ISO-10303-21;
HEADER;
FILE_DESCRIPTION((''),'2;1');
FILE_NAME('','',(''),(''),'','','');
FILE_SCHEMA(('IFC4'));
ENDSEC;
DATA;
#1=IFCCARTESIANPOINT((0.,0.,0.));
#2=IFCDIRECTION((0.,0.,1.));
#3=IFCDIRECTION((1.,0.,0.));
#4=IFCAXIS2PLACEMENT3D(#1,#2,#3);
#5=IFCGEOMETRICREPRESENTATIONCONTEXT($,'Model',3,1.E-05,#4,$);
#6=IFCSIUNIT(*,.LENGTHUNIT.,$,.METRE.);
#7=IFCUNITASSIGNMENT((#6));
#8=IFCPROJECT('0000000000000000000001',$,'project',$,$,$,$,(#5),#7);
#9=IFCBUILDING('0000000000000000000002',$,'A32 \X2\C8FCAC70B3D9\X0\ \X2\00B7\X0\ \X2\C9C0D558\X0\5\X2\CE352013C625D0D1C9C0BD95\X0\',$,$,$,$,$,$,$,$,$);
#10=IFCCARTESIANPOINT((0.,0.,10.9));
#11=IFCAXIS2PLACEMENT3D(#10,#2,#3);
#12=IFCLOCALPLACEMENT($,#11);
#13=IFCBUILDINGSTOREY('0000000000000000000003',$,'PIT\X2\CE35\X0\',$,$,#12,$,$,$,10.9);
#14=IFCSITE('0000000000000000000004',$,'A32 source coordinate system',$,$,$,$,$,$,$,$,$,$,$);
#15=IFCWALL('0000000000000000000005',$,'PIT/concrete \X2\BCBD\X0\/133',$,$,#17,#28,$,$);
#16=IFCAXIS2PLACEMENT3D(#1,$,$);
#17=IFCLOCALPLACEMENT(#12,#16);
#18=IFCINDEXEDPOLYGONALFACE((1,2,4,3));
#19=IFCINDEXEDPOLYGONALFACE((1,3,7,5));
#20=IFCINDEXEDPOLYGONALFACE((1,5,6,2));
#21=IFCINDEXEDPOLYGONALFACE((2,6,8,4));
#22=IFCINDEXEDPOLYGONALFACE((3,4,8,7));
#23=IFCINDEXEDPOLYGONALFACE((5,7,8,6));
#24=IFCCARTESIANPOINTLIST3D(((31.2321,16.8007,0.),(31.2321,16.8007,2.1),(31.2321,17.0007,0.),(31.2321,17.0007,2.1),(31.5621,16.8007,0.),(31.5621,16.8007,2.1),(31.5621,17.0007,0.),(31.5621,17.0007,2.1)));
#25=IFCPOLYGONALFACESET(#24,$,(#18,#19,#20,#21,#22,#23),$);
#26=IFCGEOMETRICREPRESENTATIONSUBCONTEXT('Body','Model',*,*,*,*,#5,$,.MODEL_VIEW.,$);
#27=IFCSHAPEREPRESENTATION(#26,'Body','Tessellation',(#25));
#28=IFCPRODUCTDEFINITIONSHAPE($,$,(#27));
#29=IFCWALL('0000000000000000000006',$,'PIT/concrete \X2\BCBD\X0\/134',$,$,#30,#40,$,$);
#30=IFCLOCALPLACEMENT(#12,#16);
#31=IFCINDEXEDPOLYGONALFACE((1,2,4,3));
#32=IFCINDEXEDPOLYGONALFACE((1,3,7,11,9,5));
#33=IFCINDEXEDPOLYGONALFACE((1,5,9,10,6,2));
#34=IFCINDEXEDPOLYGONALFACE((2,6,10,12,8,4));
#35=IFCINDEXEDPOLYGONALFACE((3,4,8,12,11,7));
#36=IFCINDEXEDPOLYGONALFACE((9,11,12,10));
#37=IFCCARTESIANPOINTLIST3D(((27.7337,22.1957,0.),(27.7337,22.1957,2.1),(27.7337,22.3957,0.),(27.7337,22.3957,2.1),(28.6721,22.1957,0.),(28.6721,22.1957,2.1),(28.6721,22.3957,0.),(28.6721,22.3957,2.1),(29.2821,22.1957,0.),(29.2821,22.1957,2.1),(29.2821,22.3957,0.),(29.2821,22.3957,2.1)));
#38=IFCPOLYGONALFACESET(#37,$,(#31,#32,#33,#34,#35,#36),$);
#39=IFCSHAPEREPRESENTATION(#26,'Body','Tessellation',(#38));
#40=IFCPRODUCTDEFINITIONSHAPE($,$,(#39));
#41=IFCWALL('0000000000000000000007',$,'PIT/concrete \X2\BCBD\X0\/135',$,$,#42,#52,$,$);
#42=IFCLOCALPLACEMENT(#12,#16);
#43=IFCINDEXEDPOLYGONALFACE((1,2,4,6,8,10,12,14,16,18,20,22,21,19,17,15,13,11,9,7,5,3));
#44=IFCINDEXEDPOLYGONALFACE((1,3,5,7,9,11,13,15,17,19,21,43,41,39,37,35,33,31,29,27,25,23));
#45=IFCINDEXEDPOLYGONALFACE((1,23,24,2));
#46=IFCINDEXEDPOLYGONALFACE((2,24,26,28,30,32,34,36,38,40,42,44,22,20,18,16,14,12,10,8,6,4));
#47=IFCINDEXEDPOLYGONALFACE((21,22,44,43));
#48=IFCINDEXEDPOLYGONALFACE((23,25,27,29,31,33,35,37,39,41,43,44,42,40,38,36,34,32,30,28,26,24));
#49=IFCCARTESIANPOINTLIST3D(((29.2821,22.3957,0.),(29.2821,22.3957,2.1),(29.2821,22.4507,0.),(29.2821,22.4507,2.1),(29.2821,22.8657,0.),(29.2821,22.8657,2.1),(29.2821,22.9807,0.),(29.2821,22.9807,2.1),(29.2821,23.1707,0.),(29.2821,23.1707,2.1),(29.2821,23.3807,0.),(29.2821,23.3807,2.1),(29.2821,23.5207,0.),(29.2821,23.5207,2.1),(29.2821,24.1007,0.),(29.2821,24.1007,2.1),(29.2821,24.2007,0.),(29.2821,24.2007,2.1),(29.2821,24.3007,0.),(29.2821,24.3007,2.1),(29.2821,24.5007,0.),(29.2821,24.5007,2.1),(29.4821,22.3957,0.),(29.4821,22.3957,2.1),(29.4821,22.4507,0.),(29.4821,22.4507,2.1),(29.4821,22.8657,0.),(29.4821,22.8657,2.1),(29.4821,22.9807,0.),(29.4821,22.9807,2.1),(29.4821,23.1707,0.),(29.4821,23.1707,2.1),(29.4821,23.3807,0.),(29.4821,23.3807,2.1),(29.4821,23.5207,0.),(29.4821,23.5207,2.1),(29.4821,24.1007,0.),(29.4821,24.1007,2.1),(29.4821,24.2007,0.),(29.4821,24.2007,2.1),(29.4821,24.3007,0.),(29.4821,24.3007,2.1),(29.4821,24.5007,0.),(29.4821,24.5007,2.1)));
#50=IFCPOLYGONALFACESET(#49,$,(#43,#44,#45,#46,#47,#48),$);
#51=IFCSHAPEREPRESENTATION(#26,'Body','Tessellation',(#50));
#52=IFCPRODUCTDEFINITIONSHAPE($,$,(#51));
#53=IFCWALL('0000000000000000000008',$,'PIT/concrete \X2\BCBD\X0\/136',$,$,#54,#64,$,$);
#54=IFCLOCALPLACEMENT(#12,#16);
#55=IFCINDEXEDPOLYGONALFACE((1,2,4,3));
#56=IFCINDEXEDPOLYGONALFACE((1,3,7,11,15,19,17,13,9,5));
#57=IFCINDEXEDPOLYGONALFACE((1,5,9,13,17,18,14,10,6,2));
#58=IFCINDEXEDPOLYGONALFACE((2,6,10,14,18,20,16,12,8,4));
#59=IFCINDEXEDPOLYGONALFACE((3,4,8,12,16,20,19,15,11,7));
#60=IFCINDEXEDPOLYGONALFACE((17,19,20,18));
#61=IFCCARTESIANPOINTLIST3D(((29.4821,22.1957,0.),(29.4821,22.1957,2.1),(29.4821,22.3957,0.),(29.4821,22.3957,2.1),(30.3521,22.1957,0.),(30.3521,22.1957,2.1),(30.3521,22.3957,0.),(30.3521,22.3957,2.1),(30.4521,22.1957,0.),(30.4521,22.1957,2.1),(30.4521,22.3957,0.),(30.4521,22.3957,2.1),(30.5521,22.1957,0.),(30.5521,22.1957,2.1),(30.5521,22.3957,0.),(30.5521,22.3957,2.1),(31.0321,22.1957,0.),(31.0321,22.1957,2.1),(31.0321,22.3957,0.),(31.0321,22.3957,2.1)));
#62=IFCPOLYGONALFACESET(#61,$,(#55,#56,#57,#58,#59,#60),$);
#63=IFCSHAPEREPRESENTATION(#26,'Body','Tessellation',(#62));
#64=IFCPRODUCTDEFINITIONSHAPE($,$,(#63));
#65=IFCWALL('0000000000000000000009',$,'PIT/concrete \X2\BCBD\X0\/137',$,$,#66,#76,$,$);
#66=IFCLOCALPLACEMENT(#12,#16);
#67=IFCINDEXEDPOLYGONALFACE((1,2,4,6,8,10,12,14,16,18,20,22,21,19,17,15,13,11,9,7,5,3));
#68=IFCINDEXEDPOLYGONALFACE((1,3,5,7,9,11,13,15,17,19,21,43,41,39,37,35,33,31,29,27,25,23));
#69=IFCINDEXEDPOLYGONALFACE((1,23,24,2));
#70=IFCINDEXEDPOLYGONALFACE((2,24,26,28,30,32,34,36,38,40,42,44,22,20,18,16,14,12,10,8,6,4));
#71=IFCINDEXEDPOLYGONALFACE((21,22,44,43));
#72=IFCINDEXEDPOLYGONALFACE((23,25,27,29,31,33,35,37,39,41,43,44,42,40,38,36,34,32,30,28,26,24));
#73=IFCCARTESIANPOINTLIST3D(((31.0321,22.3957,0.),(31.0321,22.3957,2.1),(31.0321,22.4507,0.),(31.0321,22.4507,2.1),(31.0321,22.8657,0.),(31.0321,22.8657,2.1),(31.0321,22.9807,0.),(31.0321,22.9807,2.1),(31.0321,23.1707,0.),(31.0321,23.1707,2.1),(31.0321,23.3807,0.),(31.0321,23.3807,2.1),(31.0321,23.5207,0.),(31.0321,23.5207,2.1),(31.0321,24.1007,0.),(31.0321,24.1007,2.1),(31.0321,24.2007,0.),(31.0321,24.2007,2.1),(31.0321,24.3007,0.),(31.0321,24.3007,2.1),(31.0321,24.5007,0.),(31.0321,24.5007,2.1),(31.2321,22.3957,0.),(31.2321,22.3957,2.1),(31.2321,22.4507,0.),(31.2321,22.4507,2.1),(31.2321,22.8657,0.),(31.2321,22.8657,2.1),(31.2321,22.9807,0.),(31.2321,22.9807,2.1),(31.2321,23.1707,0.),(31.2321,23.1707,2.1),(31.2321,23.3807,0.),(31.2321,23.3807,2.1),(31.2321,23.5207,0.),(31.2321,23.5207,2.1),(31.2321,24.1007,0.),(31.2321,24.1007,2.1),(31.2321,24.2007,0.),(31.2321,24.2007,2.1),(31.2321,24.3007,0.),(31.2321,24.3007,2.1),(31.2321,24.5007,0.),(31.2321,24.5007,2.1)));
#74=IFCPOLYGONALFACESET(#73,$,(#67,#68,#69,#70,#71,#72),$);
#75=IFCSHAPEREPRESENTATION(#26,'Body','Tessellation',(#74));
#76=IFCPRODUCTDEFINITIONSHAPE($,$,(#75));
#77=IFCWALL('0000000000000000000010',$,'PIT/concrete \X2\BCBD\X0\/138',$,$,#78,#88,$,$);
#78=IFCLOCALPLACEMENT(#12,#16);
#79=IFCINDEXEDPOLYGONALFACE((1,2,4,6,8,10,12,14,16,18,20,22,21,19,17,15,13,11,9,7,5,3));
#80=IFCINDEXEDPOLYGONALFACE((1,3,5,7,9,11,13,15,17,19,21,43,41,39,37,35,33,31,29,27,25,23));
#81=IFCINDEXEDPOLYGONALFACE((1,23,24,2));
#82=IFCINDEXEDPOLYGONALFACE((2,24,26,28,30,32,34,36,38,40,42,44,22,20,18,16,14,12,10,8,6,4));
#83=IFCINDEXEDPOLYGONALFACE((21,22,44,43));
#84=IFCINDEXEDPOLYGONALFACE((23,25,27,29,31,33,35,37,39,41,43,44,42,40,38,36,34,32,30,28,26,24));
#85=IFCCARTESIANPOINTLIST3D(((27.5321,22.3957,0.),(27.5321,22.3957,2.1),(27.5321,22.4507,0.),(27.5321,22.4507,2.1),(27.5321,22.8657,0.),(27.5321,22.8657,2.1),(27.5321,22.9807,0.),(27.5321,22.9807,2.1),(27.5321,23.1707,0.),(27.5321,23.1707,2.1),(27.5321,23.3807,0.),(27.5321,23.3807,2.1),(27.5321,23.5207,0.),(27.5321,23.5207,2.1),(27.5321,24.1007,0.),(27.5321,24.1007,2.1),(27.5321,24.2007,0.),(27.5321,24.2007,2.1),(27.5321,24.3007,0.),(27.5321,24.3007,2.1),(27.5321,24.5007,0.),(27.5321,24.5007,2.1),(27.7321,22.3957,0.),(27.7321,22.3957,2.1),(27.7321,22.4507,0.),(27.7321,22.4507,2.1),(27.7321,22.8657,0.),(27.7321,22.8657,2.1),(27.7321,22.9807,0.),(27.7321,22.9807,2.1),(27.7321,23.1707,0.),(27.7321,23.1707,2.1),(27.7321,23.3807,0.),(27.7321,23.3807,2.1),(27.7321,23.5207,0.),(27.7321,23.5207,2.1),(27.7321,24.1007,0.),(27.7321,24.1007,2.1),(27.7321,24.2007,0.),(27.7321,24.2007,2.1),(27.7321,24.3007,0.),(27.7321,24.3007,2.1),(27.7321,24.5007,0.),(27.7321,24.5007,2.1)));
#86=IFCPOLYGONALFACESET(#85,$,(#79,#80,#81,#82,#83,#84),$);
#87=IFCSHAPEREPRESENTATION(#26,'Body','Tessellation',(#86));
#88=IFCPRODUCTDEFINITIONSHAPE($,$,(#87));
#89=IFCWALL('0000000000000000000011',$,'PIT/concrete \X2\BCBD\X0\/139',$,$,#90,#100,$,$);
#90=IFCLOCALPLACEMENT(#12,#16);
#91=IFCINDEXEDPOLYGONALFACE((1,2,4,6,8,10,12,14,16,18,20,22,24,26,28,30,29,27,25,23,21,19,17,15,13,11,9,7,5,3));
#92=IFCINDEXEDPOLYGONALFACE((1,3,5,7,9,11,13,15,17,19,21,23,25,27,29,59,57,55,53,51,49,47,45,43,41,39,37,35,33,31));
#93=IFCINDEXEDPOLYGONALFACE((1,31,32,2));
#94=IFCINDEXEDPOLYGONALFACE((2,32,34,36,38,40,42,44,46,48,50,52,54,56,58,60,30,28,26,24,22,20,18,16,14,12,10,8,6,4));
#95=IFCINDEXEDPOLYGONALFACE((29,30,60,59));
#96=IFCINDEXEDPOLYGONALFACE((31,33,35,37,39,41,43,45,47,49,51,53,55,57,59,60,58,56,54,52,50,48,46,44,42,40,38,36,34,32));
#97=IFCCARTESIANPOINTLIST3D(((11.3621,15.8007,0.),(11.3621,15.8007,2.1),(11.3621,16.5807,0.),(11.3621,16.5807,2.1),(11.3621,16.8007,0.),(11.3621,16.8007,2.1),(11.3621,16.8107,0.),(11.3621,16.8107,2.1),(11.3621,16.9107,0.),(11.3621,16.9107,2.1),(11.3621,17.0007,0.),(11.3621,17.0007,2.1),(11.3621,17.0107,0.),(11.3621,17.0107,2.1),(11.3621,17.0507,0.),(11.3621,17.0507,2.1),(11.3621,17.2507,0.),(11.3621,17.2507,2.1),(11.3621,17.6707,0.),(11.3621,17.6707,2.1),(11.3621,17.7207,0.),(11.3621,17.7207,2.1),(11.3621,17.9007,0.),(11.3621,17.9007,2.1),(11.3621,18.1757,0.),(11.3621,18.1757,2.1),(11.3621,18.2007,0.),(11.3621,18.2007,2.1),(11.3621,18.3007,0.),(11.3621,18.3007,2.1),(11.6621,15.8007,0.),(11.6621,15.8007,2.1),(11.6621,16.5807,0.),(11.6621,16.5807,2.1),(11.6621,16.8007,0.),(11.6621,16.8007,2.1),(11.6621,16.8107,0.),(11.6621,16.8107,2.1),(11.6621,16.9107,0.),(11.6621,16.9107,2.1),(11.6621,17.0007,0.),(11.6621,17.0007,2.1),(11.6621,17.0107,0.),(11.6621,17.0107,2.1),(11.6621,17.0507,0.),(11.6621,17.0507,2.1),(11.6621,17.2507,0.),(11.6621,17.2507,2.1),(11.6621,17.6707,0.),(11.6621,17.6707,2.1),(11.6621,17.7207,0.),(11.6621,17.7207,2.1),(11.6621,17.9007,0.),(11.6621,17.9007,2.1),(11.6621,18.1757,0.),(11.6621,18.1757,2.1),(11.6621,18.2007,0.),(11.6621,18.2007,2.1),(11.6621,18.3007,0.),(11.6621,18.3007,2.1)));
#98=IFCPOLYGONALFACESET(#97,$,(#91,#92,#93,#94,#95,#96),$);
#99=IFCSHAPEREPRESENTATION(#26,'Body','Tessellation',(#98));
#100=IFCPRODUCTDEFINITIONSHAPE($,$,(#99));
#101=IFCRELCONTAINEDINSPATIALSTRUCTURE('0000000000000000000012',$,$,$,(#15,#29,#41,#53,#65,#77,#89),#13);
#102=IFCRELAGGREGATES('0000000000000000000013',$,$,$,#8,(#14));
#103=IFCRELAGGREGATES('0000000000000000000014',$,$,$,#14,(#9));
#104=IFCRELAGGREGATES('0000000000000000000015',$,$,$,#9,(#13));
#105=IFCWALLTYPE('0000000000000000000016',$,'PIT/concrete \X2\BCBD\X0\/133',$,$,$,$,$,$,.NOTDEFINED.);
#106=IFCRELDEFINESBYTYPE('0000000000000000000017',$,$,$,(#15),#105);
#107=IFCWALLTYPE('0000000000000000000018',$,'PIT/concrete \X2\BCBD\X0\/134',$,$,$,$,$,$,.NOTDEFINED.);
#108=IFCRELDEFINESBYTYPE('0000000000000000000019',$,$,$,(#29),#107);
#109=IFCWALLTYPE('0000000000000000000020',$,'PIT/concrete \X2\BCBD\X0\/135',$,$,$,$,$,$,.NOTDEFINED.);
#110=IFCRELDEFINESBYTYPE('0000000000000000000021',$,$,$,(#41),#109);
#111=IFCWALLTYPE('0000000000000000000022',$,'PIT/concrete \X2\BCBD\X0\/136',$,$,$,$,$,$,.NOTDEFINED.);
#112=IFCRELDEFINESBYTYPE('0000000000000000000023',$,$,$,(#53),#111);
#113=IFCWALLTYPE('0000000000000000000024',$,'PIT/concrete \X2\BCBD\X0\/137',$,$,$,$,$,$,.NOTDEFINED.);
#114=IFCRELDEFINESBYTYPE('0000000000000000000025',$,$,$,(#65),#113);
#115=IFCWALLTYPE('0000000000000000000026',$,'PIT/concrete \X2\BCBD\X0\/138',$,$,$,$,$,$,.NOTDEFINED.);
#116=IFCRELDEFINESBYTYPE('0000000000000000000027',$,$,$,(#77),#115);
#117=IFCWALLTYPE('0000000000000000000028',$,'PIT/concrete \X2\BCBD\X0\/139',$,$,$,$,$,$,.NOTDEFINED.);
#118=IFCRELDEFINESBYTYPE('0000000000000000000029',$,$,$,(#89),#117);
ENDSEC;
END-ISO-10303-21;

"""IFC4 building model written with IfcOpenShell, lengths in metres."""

from ifc_helpers import new_model, si_unit, frame, origin, origin_with_axes, place, context, subcontext, project, spatial, polyline, outline, extrude, source, transform, mapped, type_object, type_shapes, element, save


model = new_model("IFC4")

# Units and contexts
model_context = context("Model", 3, precision=1e-05, world=origin_with_axes())
body_context = subcontext(model_context, "Body", "Model", "MODEL_VIEW")
ifc_project = project(units=[si_unit("LENGTHUNIT", "METRE")], contexts=[model_context])

# Site, building, storey
site = spatial("IfcSite", under=ifc_project, Name="A32 source coordinate system")
building = spatial("IfcBuilding", under=site, Name="A32 주거동 · 지하5층–옥탑지붕")
storey_placement = place(None, frame((0.0, 0.0, 10.9), z_axis=(0.0, 0.0, 1.0), x_axis=(1.0, 0.0, 0.0)))
storey = spatial("IfcBuildingStorey", under=building, at=storey_placement, Name="PIT층", Elevation=10.9)

# Walls
wall_type_1 = type_object("IfcWallType", Name="PIT/concrete 벽/133", PredefinedType="NOTDEFINED")
shared_shape_1 = source(origin(), body_context, "Body", "SweptSolid", [
    extrude(outline(polyline([(31.2321, 16.8007), (31.2321, 17.0007), (31.5621, 17.0007), (31.5621, 16.8007), (31.2321, 16.8007)])), origin(), (0.0, 0.0, 1.0), 2.1),
])
type_shapes(wall_type_1, [shared_shape_1])
wall_1_placement = place(storey_placement, origin_with_axes())
element("IfcWall", 1, at=wall_1_placement, inside=storey, type_object=wall_type_1, Name="PIT/concrete 벽/133", context=body_context, shape_type="MappedRepresentation", body=[
    mapped(shared_shape_1, transform((0.0, 0.0, 0.0), scale=1.0)),
])
wall_type_2 = type_object("IfcWallType", Name="PIT/concrete 벽/134", PredefinedType="NOTDEFINED")
shared_shape_2 = source(origin(), body_context, "Body", "SweptSolid", [
    extrude(outline(polyline([(29.2821, 22.3957), (29.2821, 22.1957), (28.6721, 22.1957), (27.7337, 22.1957), (27.7337, 22.3957), (28.6721, 22.3957), (29.2821, 22.3957)])), origin(), (0.0, 0.0, 1.0), 2.1),
])
type_shapes(wall_type_2, [shared_shape_2])
wall_2_placement = place(storey_placement, origin_with_axes())
element("IfcWall", 2, at=wall_2_placement, inside=storey, type_object=wall_type_2, Name="PIT/concrete 벽/134", context=body_context, shape_type="MappedRepresentation", body=[
    mapped(shared_shape_2, transform((0.0, 0.0, 0.0), scale=1.0)),
])
wall_type_3 = type_object("IfcWallType", Name="PIT/concrete 벽/135", PredefinedType="NOTDEFINED")
shared_shape_3 = source(origin(), body_context, "Body", "SweptSolid", [
    extrude(outline(polyline([(29.2821, 22.9807), (29.2821, 23.1707), (29.2821, 23.3807), (29.2821, 23.5207), (29.2821, 24.1007), (29.2821, 24.2007), (29.2821, 24.3007), (29.2821, 24.5007), (29.4821, 24.5007), (29.4821, 24.3007), (29.4821, 24.2007), (29.4821, 24.1007), (29.4821, 23.5207), (29.4821, 23.3807), (29.4821, 23.1707), (29.4821, 22.9807), (29.4821, 22.8657), (29.4821, 22.4507), (29.4821, 22.3957), (29.2821, 22.3957), (29.2821, 22.4507), (29.2821, 22.8657), (29.2821, 22.9807)])), origin(), (0.0, 0.0, 1.0), 2.1),
])
type_shapes(wall_type_3, [shared_shape_3])
wall_3_placement = place(storey_placement, origin_with_axes())
element("IfcWall", 3, at=wall_3_placement, inside=storey, type_object=wall_type_3, Name="PIT/concrete 벽/135", context=body_context, shape_type="MappedRepresentation", body=[
    mapped(shared_shape_3, transform((0.0, 0.0, 0.0), scale=1.0)),
])
wall_type_4 = type_object("IfcWallType", Name="PIT/concrete 벽/136", PredefinedType="NOTDEFINED")
shared_shape_4 = source(origin(), body_context, "Body", "SweptSolid", [
    extrude(outline(polyline([(30.5521, 22.3957), (31.0321, 22.3957), (31.0321, 22.1957), (30.5521, 22.1957), (30.4521, 22.1957), (30.3521, 22.1957), (29.4821, 22.1957), (29.4821, 22.3957), (30.3521, 22.3957), (30.4521, 22.3957), (30.5521, 22.3957)])), origin(), (0.0, 0.0, 1.0), 2.1),
])
type_shapes(wall_type_4, [shared_shape_4])
wall_4_placement = place(storey_placement, origin_with_axes())
element("IfcWall", 4, at=wall_4_placement, inside=storey, type_object=wall_type_4, Name="PIT/concrete 벽/136", context=body_context, shape_type="MappedRepresentation", body=[
    mapped(shared_shape_4, transform((0.0, 0.0, 0.0), scale=1.0)),
])
wall_type_5 = type_object("IfcWallType", Name="PIT/concrete 벽/137", PredefinedType="NOTDEFINED")
shared_shape_5 = source(origin(), body_context, "Body", "SweptSolid", [
    extrude(outline(polyline([(31.0321, 22.9807), (31.0321, 23.1707), (31.0321, 23.3807), (31.0321, 23.5207), (31.0321, 24.1007), (31.0321, 24.2007), (31.0321, 24.3007), (31.0321, 24.5007), (31.2321, 24.5007), (31.2321, 24.3007), (31.2321, 24.2007), (31.2321, 24.1007), (31.2321, 23.5207), (31.2321, 23.3807), (31.2321, 23.1707), (31.2321, 22.9807), (31.2321, 22.8657), (31.2321, 22.4507), (31.2321, 22.3957), (31.0321, 22.3957), (31.0321, 22.4507), (31.0321, 22.8657), (31.0321, 22.9807)])), origin(), (0.0, 0.0, 1.0), 2.1),
])
type_shapes(wall_type_5, [shared_shape_5])
wall_5_placement = place(storey_placement, origin_with_axes())
element("IfcWall", 5, at=wall_5_placement, inside=storey, type_object=wall_type_5, Name="PIT/concrete 벽/137", context=body_context, shape_type="MappedRepresentation", body=[
    mapped(shared_shape_5, transform((0.0, 0.0, 0.0), scale=1.0)),
])
wall_type_6 = type_object("IfcWallType", Name="PIT/concrete 벽/138", PredefinedType="NOTDEFINED")
shared_shape_6 = source(origin(), body_context, "Body", "SweptSolid", [
    extrude(outline(polyline([(27.7321, 24.3007), (27.7321, 24.2007), (27.7321, 24.1007), (27.7321, 23.5207), (27.7321, 23.3807), (27.7321, 23.1707), (27.7321, 22.9807), (27.7321, 22.8657), (27.7321, 22.4507), (27.7321, 22.3957), (27.5321, 22.3957), (27.5321, 22.4507), (27.5321, 22.8657), (27.5321, 22.9807), (27.5321, 23.1707), (27.5321, 23.3807), (27.5321, 23.5207), (27.5321, 24.1007), (27.5321, 24.2007), (27.5321, 24.3007), (27.5321, 24.5007), (27.7321, 24.5007), (27.7321, 24.3007)])), origin(), (0.0, 0.0, 1.0), 2.1),
])
type_shapes(wall_type_6, [shared_shape_6])
wall_6_placement = place(storey_placement, origin_with_axes())
element("IfcWall", 6, at=wall_6_placement, inside=storey, type_object=wall_type_6, Name="PIT/concrete 벽/138", context=body_context, shape_type="MappedRepresentation", body=[
    mapped(shared_shape_6, transform((0.0, 0.0, 0.0), scale=1.0)),
])
wall_type_7 = type_object("IfcWallType", Name="PIT/concrete 벽/139", PredefinedType="NOTDEFINED")
shared_shape_7 = source(origin(), body_context, "Body", "SweptSolid", [
    extrude(outline(polyline([(11.3621, 17.0107), (11.3621, 17.0507), (11.3621, 17.2507), (11.3621, 17.6707), (11.3621, 17.7207), (11.3621, 17.9007), (11.3621, 18.1757), (11.3621, 18.2007), (11.3621, 18.3007), (11.6621, 18.3007), (11.6621, 18.2007), (11.6621, 18.1757), (11.6621, 17.9007), (11.6621, 17.7207), (11.6621, 17.6707), (11.6621, 17.2507), (11.6621, 17.0507), (11.6621, 17.0107), (11.6621, 17.0007), (11.6621, 16.9107), (11.6621, 16.8107), (11.6621, 16.8007), (11.6621, 16.5807), (11.6621, 15.8007), (11.3621, 15.8007), (11.3621, 16.5807), (11.3621, 16.8007), (11.3621, 16.8107), (11.3621, 16.9107), (11.3621, 17.0007), (11.3621, 17.0107)])), origin(), (0.0, 0.0, 1.0), 2.1),
])
type_shapes(wall_type_7, [shared_shape_7])
wall_7_placement = place(storey_placement, origin_with_axes())
element("IfcWall", 7, at=wall_7_placement, inside=storey, type_object=wall_type_7, Name="PIT/concrete 벽/139", context=body_context, shape_type="MappedRepresentation", body=[
    mapped(shared_shape_7, transform((0.0, 0.0, 0.0), scale=1.0)),
])

save(model, "model.ifc")
